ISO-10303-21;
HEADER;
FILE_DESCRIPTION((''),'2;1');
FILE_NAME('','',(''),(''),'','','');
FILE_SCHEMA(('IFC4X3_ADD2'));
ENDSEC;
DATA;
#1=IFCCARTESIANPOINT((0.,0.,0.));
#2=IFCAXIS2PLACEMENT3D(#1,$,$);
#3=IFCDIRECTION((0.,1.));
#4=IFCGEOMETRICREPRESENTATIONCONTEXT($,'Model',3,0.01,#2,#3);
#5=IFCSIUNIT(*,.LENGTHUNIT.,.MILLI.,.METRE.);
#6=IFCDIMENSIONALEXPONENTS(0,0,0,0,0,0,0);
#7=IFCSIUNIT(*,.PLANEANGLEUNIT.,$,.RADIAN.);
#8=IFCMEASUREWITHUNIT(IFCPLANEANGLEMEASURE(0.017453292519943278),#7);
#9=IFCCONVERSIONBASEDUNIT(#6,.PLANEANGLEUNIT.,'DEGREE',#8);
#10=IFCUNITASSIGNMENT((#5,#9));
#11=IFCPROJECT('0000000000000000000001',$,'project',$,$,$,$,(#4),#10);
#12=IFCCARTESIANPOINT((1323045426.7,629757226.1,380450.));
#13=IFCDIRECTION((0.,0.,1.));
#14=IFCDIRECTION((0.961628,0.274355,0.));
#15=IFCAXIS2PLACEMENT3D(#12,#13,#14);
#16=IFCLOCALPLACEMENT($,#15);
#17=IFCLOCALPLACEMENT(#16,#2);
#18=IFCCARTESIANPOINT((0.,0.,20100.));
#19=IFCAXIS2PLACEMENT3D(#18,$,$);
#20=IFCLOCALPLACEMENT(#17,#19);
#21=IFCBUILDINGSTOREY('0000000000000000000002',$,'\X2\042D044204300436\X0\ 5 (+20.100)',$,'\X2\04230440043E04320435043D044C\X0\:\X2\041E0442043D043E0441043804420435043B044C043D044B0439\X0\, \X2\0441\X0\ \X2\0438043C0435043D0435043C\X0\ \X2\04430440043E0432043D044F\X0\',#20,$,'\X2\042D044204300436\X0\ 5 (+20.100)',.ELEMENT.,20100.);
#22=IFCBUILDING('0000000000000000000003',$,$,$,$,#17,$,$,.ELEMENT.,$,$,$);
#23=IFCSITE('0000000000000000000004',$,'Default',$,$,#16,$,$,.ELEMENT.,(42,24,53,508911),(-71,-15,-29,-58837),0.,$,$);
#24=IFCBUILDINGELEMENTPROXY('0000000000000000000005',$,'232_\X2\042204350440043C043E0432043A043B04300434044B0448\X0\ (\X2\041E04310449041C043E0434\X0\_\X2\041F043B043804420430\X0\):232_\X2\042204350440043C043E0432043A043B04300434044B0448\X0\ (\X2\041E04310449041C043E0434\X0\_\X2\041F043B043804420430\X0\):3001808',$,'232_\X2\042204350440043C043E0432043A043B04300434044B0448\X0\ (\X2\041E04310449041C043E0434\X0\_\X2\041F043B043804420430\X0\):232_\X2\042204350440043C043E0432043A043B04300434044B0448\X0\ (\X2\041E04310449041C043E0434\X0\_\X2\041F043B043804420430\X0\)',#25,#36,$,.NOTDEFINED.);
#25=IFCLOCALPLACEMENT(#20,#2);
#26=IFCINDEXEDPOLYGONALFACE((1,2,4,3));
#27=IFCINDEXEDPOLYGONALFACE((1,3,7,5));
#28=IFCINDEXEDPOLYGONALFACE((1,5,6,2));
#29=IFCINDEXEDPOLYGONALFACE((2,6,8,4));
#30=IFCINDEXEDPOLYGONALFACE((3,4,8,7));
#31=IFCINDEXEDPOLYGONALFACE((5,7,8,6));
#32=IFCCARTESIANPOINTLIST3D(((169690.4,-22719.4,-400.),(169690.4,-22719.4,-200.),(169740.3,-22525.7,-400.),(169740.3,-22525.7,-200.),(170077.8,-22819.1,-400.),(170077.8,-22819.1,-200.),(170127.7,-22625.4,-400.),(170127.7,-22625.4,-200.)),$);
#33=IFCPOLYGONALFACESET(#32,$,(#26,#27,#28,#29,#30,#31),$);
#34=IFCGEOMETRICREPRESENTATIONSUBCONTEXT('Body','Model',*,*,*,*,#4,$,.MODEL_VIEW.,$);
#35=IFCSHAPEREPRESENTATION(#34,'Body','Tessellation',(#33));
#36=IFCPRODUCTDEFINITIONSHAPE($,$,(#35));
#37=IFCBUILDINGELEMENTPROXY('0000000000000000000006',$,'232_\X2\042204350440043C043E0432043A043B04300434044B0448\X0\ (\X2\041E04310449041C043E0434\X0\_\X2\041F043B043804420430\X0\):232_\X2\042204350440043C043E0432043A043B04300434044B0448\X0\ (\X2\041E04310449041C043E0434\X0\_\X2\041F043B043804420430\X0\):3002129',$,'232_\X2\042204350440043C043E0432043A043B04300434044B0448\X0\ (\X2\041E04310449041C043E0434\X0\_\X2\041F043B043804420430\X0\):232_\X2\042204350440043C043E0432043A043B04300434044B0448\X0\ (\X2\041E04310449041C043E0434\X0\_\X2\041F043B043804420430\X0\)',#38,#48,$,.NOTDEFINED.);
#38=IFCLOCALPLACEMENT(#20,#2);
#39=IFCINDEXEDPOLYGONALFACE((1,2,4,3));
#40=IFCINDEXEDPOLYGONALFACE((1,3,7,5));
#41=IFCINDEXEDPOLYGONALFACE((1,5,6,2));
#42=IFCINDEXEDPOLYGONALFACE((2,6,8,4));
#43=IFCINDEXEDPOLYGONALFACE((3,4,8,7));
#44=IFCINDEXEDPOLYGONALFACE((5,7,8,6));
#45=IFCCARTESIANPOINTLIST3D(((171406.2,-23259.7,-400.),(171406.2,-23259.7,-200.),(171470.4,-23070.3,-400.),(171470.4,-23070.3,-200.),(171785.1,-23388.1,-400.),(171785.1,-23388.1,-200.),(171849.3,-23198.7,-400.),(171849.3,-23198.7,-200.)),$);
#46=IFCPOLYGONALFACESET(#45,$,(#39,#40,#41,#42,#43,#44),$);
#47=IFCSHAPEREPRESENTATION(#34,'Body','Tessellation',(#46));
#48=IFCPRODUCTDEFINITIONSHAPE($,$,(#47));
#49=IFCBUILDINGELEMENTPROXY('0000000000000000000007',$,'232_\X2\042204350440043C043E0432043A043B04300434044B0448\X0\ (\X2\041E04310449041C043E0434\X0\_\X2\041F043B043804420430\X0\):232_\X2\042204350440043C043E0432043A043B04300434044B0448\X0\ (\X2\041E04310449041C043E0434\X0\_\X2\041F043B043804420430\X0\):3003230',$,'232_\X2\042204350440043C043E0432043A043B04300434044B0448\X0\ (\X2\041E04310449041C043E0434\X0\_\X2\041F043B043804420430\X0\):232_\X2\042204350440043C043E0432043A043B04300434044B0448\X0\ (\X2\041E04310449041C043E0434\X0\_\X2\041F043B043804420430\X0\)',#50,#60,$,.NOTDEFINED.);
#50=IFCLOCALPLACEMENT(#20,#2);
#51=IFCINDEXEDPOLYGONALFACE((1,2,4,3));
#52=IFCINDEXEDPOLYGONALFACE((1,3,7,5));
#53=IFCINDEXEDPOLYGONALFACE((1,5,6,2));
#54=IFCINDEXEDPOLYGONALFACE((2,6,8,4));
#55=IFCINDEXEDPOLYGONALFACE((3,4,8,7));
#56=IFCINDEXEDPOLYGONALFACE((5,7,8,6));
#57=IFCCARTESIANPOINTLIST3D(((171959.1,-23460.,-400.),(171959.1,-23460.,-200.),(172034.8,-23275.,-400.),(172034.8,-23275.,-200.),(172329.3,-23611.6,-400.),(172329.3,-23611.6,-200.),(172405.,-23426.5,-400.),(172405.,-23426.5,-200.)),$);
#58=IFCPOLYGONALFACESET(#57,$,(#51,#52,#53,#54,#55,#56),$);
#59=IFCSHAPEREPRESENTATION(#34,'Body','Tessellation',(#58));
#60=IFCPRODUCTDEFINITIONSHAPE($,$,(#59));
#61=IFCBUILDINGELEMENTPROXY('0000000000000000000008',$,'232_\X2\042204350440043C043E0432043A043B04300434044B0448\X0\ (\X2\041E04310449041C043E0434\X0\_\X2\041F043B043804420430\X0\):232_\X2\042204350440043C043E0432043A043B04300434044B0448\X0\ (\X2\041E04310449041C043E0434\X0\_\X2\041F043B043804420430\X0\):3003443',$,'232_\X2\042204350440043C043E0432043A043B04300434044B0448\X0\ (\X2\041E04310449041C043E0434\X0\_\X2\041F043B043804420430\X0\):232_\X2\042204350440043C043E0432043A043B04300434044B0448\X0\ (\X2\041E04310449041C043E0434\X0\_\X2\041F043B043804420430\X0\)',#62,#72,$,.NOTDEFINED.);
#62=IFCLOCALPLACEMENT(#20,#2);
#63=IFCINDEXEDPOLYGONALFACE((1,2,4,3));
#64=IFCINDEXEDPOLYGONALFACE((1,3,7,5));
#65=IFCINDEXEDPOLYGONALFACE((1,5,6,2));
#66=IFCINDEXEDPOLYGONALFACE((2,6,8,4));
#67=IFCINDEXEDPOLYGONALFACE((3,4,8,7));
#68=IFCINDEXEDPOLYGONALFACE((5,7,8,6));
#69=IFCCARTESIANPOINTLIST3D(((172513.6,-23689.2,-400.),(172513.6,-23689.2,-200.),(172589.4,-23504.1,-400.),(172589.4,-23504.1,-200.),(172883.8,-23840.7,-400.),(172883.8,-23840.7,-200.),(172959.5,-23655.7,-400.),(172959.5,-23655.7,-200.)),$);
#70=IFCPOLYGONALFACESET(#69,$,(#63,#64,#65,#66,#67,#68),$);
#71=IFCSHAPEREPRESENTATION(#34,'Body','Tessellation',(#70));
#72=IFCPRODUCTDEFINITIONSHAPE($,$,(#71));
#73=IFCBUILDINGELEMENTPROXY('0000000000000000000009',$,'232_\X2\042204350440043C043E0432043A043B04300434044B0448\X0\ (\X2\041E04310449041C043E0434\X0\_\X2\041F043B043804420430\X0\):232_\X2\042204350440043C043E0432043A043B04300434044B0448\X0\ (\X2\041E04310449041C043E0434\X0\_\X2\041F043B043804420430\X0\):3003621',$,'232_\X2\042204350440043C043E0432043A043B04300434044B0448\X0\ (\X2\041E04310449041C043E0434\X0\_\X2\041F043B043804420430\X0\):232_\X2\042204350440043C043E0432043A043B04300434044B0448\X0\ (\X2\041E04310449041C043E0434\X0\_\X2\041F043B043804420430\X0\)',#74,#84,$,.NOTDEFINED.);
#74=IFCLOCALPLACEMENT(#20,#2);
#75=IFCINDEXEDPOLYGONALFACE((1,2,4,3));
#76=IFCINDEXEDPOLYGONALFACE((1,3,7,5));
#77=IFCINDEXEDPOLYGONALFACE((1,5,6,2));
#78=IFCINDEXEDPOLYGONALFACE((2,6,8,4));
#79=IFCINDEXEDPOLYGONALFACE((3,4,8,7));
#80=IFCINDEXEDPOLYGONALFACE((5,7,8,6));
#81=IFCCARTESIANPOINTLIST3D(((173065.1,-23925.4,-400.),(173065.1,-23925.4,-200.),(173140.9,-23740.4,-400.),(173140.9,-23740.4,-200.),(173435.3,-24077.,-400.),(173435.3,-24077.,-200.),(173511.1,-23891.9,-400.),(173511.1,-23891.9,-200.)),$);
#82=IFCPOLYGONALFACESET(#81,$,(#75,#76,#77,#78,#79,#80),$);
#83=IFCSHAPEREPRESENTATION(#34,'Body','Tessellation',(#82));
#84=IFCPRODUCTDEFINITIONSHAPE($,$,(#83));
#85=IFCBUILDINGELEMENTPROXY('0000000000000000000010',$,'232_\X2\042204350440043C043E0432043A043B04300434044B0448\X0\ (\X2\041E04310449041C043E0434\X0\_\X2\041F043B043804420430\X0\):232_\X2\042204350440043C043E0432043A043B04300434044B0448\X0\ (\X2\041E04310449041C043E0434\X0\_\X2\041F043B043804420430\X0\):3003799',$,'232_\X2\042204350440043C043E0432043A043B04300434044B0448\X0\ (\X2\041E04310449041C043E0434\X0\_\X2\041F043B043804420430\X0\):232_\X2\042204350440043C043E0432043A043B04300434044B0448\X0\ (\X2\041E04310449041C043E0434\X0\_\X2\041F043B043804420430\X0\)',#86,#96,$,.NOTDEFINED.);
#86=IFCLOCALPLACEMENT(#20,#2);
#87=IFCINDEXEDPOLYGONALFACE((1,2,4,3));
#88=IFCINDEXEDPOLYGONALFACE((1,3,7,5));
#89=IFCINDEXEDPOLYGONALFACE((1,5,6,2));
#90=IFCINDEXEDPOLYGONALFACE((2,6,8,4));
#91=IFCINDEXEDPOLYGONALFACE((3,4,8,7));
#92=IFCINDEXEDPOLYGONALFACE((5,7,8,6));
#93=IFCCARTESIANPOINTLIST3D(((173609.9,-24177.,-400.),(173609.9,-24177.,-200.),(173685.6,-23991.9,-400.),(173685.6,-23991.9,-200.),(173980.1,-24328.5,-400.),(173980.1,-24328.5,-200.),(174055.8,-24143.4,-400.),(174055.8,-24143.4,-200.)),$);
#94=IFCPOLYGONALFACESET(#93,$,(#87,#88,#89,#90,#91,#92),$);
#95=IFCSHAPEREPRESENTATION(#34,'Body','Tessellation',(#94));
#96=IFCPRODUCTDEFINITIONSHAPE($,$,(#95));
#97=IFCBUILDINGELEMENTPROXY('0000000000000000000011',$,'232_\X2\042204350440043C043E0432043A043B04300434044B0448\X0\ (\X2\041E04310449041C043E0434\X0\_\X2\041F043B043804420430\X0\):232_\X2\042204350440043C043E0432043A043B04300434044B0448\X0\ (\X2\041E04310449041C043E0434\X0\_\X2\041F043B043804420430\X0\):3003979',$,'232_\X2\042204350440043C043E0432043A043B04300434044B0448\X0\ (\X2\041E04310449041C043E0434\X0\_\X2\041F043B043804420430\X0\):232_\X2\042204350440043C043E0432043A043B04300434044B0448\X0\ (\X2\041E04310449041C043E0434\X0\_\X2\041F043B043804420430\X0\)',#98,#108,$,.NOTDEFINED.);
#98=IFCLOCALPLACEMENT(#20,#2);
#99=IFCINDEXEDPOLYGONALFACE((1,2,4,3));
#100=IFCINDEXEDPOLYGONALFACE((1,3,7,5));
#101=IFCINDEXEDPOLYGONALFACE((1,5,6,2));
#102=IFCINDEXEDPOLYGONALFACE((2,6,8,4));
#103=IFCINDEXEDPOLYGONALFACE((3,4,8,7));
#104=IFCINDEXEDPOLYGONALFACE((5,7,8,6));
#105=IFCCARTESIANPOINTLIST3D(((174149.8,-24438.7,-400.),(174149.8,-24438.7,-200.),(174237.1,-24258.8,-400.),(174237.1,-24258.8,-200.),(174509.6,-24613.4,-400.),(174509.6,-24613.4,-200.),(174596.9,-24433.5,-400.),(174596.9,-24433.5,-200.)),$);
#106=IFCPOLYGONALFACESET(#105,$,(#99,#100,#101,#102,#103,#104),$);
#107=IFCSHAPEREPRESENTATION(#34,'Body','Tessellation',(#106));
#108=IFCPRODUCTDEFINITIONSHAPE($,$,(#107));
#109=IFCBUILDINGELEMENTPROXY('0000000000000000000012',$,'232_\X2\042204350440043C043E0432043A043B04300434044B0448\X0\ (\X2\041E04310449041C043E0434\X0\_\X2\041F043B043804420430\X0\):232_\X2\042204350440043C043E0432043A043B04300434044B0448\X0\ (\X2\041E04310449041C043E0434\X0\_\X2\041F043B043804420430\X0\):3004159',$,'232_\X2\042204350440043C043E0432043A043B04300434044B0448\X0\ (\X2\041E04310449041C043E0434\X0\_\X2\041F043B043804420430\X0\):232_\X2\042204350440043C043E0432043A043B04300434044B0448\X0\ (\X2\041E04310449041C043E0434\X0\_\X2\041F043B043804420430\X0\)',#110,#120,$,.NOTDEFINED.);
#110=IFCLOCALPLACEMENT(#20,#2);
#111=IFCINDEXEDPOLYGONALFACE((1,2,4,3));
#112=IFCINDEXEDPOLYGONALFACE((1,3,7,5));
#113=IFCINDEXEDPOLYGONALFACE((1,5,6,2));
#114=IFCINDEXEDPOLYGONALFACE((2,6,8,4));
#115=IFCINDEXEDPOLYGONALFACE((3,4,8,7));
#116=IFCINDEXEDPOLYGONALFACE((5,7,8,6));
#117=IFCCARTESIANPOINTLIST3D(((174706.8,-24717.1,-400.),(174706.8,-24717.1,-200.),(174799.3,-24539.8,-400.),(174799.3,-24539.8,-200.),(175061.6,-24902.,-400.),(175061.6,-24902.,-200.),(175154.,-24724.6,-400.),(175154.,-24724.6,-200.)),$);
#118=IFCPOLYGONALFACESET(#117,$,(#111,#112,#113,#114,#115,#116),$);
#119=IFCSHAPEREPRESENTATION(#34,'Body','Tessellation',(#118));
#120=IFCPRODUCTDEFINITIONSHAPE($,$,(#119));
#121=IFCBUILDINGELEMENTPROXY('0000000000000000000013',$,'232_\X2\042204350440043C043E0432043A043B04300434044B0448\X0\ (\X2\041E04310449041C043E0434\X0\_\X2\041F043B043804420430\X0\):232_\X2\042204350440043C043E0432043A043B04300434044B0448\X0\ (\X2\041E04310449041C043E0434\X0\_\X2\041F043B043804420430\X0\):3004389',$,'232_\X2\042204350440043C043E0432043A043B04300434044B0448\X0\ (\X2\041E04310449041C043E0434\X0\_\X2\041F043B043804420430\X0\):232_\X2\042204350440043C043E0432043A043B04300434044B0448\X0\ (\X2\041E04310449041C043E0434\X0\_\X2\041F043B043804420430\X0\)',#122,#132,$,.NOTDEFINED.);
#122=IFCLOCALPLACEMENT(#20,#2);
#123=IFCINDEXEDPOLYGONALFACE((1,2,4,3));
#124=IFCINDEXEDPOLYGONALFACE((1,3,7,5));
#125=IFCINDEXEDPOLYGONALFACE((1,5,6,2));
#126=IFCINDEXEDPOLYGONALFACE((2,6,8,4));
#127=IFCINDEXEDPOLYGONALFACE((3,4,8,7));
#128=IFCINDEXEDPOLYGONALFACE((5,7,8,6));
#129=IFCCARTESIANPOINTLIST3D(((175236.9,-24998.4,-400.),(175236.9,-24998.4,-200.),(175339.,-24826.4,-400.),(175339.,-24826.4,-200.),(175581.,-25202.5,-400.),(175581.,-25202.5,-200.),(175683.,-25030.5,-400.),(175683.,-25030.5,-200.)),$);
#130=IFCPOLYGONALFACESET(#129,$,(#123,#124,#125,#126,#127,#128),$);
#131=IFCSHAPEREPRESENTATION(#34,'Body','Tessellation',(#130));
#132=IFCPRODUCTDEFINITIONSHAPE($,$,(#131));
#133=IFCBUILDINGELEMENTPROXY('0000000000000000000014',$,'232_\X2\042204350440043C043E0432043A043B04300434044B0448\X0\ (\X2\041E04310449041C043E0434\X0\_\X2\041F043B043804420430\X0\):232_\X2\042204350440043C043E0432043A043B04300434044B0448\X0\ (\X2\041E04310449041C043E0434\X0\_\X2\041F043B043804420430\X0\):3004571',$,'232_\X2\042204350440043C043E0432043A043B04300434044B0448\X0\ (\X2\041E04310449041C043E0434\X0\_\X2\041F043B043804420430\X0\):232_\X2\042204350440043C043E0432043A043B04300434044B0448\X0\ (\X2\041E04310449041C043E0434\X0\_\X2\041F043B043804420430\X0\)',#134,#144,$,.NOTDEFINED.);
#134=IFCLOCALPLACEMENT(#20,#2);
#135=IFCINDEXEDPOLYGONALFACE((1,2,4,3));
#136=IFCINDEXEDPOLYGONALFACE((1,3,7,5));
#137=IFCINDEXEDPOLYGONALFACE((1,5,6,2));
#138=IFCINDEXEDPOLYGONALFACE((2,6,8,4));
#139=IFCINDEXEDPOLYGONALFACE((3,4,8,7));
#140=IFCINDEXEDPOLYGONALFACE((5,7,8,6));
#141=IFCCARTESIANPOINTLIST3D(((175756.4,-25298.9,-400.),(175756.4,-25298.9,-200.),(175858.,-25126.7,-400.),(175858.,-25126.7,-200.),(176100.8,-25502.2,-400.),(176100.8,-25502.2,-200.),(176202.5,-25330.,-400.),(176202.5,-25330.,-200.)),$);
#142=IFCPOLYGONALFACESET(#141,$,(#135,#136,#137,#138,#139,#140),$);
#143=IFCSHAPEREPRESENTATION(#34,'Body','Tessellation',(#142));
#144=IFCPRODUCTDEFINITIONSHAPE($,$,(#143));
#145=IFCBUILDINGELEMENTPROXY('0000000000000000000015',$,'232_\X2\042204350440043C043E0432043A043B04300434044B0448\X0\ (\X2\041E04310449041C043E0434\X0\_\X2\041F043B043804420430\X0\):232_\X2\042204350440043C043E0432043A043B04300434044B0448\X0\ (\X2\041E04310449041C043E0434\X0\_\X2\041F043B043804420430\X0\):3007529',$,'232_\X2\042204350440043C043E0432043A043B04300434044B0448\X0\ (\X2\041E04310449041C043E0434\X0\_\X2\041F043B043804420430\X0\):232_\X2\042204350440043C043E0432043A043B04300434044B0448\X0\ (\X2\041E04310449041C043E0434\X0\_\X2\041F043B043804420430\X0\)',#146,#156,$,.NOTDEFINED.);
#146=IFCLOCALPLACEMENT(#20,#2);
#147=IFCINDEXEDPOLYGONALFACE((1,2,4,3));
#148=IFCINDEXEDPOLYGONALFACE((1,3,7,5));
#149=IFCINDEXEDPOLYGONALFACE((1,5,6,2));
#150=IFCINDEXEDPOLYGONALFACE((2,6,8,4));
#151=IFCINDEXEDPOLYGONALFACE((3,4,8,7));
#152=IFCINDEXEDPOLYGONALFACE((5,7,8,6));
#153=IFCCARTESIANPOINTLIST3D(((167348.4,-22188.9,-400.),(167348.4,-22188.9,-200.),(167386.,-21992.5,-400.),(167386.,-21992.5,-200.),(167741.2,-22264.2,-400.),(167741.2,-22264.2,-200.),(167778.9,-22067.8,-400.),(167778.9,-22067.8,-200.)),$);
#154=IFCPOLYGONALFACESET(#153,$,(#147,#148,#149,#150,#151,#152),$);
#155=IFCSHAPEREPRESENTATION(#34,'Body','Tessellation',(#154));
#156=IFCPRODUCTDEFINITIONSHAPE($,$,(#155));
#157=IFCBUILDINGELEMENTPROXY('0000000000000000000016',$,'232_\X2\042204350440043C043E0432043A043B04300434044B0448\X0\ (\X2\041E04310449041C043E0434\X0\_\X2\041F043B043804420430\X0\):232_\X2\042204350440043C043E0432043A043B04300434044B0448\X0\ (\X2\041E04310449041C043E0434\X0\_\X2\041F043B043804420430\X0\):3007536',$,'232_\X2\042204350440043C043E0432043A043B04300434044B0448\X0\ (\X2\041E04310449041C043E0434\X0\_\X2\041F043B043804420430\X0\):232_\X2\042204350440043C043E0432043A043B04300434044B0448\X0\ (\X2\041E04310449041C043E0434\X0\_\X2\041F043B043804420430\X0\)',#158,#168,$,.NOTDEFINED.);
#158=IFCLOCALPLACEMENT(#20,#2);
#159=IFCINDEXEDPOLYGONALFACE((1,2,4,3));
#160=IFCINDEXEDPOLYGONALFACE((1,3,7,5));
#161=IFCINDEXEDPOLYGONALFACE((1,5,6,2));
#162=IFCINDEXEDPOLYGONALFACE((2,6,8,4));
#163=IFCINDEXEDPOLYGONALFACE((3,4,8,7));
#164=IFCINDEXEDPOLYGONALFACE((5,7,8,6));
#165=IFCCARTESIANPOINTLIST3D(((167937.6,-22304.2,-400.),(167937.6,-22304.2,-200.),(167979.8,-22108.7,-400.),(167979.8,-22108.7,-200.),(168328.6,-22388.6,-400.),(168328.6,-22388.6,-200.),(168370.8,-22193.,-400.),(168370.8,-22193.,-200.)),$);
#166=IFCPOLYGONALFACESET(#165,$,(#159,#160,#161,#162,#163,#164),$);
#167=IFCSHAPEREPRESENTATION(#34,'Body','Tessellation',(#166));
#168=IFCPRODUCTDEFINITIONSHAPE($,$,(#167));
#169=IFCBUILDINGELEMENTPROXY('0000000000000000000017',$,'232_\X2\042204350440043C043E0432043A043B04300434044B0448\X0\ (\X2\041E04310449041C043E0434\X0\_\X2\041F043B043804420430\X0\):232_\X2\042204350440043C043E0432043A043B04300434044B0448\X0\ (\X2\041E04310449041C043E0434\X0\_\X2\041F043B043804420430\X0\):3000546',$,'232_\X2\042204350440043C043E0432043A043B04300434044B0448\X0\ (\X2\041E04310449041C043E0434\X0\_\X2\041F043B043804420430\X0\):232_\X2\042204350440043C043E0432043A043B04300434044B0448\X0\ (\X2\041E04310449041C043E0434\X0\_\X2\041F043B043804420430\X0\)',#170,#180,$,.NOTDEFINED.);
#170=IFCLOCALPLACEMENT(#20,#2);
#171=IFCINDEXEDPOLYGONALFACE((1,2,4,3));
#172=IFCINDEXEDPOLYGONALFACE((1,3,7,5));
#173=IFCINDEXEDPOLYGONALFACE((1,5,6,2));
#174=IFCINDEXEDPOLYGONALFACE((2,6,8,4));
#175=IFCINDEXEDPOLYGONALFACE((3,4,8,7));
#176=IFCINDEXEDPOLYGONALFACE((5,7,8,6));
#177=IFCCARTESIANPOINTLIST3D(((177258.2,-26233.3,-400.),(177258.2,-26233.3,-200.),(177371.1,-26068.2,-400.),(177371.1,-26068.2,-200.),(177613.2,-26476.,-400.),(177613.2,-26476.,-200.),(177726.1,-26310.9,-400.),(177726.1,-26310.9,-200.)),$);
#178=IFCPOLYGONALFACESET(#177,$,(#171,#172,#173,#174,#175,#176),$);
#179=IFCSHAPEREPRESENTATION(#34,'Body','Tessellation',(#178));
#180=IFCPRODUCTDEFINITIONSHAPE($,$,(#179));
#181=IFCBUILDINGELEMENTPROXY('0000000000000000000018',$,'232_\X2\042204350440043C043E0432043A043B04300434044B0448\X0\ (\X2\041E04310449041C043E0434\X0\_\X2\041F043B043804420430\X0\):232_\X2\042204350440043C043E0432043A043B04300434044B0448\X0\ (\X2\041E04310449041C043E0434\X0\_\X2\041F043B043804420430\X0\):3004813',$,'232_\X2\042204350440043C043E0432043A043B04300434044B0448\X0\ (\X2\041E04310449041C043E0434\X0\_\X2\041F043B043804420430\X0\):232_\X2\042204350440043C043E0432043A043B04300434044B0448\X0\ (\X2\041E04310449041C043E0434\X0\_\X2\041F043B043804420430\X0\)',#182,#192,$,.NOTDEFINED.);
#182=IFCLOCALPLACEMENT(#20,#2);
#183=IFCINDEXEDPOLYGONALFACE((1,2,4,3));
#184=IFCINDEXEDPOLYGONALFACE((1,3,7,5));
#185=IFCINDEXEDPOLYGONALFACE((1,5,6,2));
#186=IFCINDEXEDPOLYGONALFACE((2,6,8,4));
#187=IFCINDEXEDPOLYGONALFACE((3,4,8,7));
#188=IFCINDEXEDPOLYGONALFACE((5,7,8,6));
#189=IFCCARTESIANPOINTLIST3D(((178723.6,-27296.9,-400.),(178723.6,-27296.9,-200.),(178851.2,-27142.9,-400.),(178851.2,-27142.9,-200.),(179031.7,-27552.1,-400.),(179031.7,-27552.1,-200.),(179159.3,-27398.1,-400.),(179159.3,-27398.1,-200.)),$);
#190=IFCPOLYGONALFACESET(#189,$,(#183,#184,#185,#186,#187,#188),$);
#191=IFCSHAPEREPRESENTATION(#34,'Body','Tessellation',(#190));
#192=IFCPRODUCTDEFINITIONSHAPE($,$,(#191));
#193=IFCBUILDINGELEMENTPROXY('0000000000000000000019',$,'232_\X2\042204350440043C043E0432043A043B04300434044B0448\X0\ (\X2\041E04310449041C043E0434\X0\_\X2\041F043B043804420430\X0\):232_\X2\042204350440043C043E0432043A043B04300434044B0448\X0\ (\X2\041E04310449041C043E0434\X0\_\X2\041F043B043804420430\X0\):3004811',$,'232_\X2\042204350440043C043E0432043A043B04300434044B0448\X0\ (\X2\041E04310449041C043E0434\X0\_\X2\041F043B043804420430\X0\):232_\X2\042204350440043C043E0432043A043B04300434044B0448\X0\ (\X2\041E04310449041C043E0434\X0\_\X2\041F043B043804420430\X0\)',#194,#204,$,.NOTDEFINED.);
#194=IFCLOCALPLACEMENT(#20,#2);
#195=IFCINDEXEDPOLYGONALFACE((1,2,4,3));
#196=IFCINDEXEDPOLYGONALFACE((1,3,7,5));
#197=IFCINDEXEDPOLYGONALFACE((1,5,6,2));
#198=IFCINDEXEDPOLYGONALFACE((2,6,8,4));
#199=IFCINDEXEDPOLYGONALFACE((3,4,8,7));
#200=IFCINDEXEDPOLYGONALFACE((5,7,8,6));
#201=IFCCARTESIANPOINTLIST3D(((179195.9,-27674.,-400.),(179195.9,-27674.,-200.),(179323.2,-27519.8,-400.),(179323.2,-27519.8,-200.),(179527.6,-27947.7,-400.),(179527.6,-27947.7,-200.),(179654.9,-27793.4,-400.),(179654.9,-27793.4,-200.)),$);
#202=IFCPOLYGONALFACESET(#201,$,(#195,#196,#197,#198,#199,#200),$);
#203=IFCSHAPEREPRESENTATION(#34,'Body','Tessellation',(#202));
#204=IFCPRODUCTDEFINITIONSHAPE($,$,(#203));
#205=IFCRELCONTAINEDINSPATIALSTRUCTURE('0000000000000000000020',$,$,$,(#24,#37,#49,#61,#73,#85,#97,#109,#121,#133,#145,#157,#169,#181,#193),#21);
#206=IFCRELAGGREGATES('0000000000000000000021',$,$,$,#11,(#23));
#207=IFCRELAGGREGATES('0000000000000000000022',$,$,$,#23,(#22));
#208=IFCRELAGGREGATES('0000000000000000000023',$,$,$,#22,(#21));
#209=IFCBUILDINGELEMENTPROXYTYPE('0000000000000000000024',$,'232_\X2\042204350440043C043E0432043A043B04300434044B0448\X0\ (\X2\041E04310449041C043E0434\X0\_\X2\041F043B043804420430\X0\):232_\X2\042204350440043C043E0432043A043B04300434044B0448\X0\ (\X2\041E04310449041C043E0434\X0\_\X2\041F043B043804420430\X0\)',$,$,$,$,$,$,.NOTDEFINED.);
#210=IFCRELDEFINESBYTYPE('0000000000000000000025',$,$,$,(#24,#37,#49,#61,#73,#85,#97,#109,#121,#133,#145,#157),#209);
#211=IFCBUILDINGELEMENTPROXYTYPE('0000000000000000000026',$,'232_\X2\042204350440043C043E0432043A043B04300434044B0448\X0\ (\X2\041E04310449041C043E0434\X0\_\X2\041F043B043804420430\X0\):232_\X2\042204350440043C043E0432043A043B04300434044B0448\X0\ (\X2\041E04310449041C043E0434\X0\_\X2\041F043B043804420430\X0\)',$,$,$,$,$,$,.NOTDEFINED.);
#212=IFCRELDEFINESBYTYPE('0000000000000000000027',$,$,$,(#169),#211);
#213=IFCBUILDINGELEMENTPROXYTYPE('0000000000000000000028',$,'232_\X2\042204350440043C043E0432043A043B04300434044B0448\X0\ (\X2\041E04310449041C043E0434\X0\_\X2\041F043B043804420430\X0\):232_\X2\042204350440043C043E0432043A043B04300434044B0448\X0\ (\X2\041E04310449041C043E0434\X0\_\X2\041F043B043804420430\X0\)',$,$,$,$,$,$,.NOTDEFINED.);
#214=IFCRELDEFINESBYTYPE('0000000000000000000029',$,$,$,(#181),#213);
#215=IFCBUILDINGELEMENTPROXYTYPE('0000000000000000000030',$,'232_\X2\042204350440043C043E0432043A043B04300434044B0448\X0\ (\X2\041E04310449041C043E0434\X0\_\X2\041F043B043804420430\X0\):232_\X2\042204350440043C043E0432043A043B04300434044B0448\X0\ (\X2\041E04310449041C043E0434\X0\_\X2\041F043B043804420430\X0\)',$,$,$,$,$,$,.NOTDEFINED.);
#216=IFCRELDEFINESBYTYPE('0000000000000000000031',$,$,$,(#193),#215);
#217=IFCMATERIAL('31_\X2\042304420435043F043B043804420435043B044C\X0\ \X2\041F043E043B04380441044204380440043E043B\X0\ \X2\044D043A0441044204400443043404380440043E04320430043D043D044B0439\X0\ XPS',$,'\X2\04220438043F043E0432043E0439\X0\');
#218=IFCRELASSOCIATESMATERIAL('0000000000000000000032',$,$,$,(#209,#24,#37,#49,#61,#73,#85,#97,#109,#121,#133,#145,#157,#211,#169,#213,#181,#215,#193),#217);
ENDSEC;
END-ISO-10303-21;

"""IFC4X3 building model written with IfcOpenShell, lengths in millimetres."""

from ifc_helpers import new_model, entity, si_unit, converted_unit, direction, frame, origin, origin_2d_with_axis, place, context, subcontext, project, spatial, rectangle, extrude, source, transform, mapped, material, type_object, type_shapes, element, save


model = new_model("IFC4X3")

# Units and contexts
model_context = context("Model", 3, precision=0.01, world=origin(), true_north=direction((0.0, 1.0)))
body_context = subcontext(model_context, "Body", "Model", "MODEL_VIEW")
ifc_project = project(units=[si_unit("LENGTHUNIT", "METRE", prefix="MILLI"), converted_unit("PLANEANGLEUNIT", "DEGREE", entity("IfcPlaneAngleMeasure", 0.017453292519943278), si_unit("PLANEANGLEUNIT", "RADIAN"), dimensions=[0, 0, 0, 0, 0, 0, 0])], contexts=[model_context])

# Site, building, storey
site_placement = place(None, frame((1323045426.7, 629757226.1, 380450.0), z_axis=(0.0, 0.0, 1.0), x_axis=(0.961628, 0.274355, 0.0)))
site = spatial("IfcSite", under=ifc_project, at=site_placement, Name="Default", CompositionType="ELEMENT", RefLatitude=(42, 24, 53, 508911), RefLongitude=(-71, -15, -29, -58837), RefElevation=0.0)
building_placement = place(site_placement, origin())
building = spatial("IfcBuilding", under=site, at=building_placement, CompositionType="ELEMENT")
storey_placement = place(building_placement, frame((0.0, 0.0, 20100.0)))
storey = spatial("IfcBuildingStorey", under=building, at=storey_placement, Name="Этаж 5 (+20.100)", ObjectType="Уровень:Относительный, с именем уровня", LongName="Этаж 5 (+20.100)", CompositionType="ELEMENT", Elevation=20100.0)

# Building element proxies
ifc_material = material(Name="31_Утеплитель Полистирол экструдированный XPS", Category="Типовой")
building_element_proxy_type_1 = type_object("IfcBuildingElementProxyType", Name="232_Термовкладыш (ОбщМод_Плита):232_Термовкладыш (ОбщМод_Плита)", PredefinedType="NOTDEFINED", material=ifc_material)
shared_shape_1 = source(origin(), body_context, "Body", "SweptSolid", [
    extrude(rectangle(XDim=400.0, YDim=200.0, at=origin_2d_with_axis()), frame((200.0, 0.0, -200.0), z_axis=(0.0, 0.0, 1.0), x_axis=(-1.0, 0.0, 0.0)), (0.0, 0.0, 1.0), 200.0),
])
type_shapes(building_element_proxy_type_1, [shared_shape_1])
for number, where, z_axis, x_axis, name in (
    (1, (169715.4, -22622.6, -200.0), (0.0, 0.0, 1.0), (0.968469, -0.249135, 0.0), "232_Термовкладыш (ОбщМод_Плита):232_Термовкладыш (ОбщМод_Плита):3001808"),
    (2, (171438.3, -23165.0, -200.0), (0.0, 0.0, 1.0), (0.947097, -0.320946, 0.0), "232_Термовкладыш (ОбщМод_Плита):232_Термовкладыш (ОбщМод_Плита):3002129"),
    (3, (171997.0, -23367.5, -200.0), (0.0, 0.0, 1.0), (0.925465, -0.378833, 0.0), "232_Термовкладыш (ОбщМод_Плита):232_Термовкладыш (ОбщМод_Плита):3003230"),
    (4, (172551.5, -23596.7, -200.0), (0.0, 0.0, 1.0), (0.925465, -0.378833, 0.0), "232_Термовкладыш (ОбщМод_Плита):232_Термовкладыш (ОбщМод_Плита):3003443"),
    (5, (173103.0, -23832.9, -200.0), (0.0, 0.0, 1.0), (0.925465, -0.378833, 0.0), "232_Термовкладыш (ОбщМод_Плита):232_Термовкладыш (ОбщМод_Плита):3003621"),
    (6, (173647.8, -24084.4, -200.0), (0.0, 0.0, 1.0), (0.925465, -0.378833, 0.0), "232_Термовкладыш (ОбщМод_Плита):232_Термовкладыш (ОбщМод_Плита):3003799"),
    (7, (174193.4, -24348.7, -200.0), (0.0, 0.0, 1.0), (0.899546, -0.436827, 0.0), "232_Термовкладыш (ОбщМод_Плита):232_Термовкладыш (ОбщМод_Плита):3003979"),
    (8, (174753.0, -24628.5, -200.0), (0.0, 0.0, 1.0), (0.886816, -0.462122, 0.0), "232_Термовкладыш (ОбщМод_Плита):232_Термовкладыш (ОбщМод_Плита):3004159"),
    (9, (175287.9, -24912.4, -200.0), (0.0, 0.0, 1.0), (0.860118, -0.510095, 0.0), "232_Термовкладыш (ОбщМод_Плита):232_Термовкладыш (ОбщМод_Плита):3004389"),
    (10, (175807.2, -25212.8, -200.0), (0.0, 0.0, 1.0), (0.861177, -0.508304, 0.0), "232_Термовкладыш (ОбщМод_Плита):232_Термовкладыш (ОбщМод_Плита):3004571"),
    (11, (167367.2, -22090.7, -200.0), (0.0, 0.0, 1.0), (0.982102, -0.188348, 0.0), "232_Термовкладыш (ОбщМод_Плита):232_Термовкладыш (ОбщМод_Плита):3007529"),
    (12, (167958.7, -22206.5, -200.0), (0.0, 0.0, 1.0), (0.977537, -0.210762, 0.0), "232_Термовкладыш (ОбщМод_Плита):232_Термовкладыш (ОбщМод_Плита):3007536"),
):
    element("IfcBuildingElementProxy", number, at=place(storey_placement, frame(where, z_axis=z_axis, x_axis=x_axis)), inside=storey, type_object=building_element_proxy_type_1, material=ifc_material, Name=name, ObjectType="232_Термовкладыш (ОбщМод_Плита):232_Термовкладыш (ОбщМод_Плита)", PredefinedType="NOTDEFINED", context=body_context, shape_type="MappedRepresentation", body=[
        mapped(shared_shape_1, transform((0.0, 0.0, 0.0), scale=1.0)),
    ])
building_element_proxy_type_2 = type_object("IfcBuildingElementProxyType", Name="232_Термовкладыш (ОбщМод_Плита):232_Термовкладыш (ОбщМод_Плита)", PredefinedType="NOTDEFINED", material=ifc_material)
shared_shape_2 = source(origin(), body_context, "Body", "SweptSolid", [
    extrude(rectangle(XDim=430.0, YDim=200.0, at=origin_2d_with_axis()), frame((215.0, 0.0, -200.0), z_axis=(0.0, 0.0, 1.0), x_axis=(-1.0, 0.0, 0.0)), (0.0, 0.0, 1.0), 200.0),
])
type_shapes(building_element_proxy_type_2, [shared_shape_2])
proxy_1_placement = place(storey_placement, frame((177314.7, -26150.7, -200.0), z_axis=(0.0, 0.0, 1.0), x_axis=(0.82549, -0.564416, 0.0)))
element("IfcBuildingElementProxy", 13, at=proxy_1_placement, inside=storey, type_object=building_element_proxy_type_2, material=ifc_material, Name="232_Термовкладыш (ОбщМод_Плита):232_Термовкладыш (ОбщМод_Плита):3000546", ObjectType="232_Термовкладыш (ОбщМод_Плита):232_Термовкладыш (ОбщМод_Плита)", PredefinedType="NOTDEFINED", context=body_context, shape_type="MappedRepresentation", body=[
    mapped(shared_shape_2, transform((0.0, 0.0, 0.0), scale=1.0)),
])
building_element_proxy_type_3 = type_object("IfcBuildingElementProxyType", Name="232_Термовкладыш (ОбщМод_Плита):232_Термовкладыш (ОбщМод_Плита)", PredefinedType="NOTDEFINED", material=ifc_material)
shared_shape_3 = source(origin(), body_context, "Body", "SweptSolid", [
    extrude(rectangle(XDim=200.0, YDim=400.0, at=origin_2d_with_axis()), frame((200.0, 0.0, -200.0), z_axis=(0.0, 0.0, 1.0), x_axis=(0.0, 1.0, 0.0)), (0.0, 0.0, 1.0), 200.0),
])
type_shapes(building_element_proxy_type_3, [shared_shape_3])
proxy_2_placement = place(storey_placement, frame((179095.5, -27475.1, -200.0), z_axis=(0.0, 0.0, 1.0), x_axis=(-0.770057, 0.637976, 0.0)))
element("IfcBuildingElementProxy", 14, at=proxy_2_placement, inside=storey, type_object=building_element_proxy_type_3, material=ifc_material, Name="232_Термовкладыш (ОбщМод_Плита):232_Термовкладыш (ОбщМод_Плита):3004813", ObjectType="232_Термовкладыш (ОбщМод_Плита):232_Термовкладыш (ОбщМод_Плита)", PredefinedType="NOTDEFINED", context=body_context, shape_type="MappedRepresentation", body=[
    mapped(shared_shape_3, transform((0.0, 0.0, 0.0), scale=1.0)),
])
building_element_proxy_type_4 = type_object("IfcBuildingElementProxyType", Name="232_Термовкладыш (ОбщМод_Плита):232_Термовкладыш (ОбщМод_Плита)", PredefinedType="NOTDEFINED", material=ifc_material)
shared_shape_4 = source(origin(), body_context, "Body", "SweptSolid", [
    extrude(rectangle(XDim=200.0, YDim=430.0, at=origin_2d_with_axis()), frame((215.0, 0.0, -200.0), z_axis=(0.0, 0.0, 1.0), x_axis=(0.0, 1.0, 0.0)), (0.0, 0.0, 1.0), 200.0),
])
type_shapes(building_element_proxy_type_4, [shared_shape_4])
proxy_3_placement = place(storey_placement, frame((179591.2, -27870.5, -200.0), z_axis=(0.0, 0.0, 1.0), x_axis=(-0.771382, 0.636372, 0.0)))
element("IfcBuildingElementProxy", 15, at=proxy_3_placement, inside=storey, type_object=building_element_proxy_type_4, material=ifc_material, Name="232_Термовкладыш (ОбщМод_Плита):232_Термовкладыш (ОбщМод_Плита):3004811", ObjectType="232_Термовкладыш (ОбщМод_Плита):232_Термовкладыш (ОбщМод_Плита)", PredefinedType="NOTDEFINED", context=body_context, shape_type="MappedRepresentation", body=[
    mapped(shared_shape_4, transform((0.0, 0.0, 0.0), scale=1.0)),
])

save(model, "model.ifc")
